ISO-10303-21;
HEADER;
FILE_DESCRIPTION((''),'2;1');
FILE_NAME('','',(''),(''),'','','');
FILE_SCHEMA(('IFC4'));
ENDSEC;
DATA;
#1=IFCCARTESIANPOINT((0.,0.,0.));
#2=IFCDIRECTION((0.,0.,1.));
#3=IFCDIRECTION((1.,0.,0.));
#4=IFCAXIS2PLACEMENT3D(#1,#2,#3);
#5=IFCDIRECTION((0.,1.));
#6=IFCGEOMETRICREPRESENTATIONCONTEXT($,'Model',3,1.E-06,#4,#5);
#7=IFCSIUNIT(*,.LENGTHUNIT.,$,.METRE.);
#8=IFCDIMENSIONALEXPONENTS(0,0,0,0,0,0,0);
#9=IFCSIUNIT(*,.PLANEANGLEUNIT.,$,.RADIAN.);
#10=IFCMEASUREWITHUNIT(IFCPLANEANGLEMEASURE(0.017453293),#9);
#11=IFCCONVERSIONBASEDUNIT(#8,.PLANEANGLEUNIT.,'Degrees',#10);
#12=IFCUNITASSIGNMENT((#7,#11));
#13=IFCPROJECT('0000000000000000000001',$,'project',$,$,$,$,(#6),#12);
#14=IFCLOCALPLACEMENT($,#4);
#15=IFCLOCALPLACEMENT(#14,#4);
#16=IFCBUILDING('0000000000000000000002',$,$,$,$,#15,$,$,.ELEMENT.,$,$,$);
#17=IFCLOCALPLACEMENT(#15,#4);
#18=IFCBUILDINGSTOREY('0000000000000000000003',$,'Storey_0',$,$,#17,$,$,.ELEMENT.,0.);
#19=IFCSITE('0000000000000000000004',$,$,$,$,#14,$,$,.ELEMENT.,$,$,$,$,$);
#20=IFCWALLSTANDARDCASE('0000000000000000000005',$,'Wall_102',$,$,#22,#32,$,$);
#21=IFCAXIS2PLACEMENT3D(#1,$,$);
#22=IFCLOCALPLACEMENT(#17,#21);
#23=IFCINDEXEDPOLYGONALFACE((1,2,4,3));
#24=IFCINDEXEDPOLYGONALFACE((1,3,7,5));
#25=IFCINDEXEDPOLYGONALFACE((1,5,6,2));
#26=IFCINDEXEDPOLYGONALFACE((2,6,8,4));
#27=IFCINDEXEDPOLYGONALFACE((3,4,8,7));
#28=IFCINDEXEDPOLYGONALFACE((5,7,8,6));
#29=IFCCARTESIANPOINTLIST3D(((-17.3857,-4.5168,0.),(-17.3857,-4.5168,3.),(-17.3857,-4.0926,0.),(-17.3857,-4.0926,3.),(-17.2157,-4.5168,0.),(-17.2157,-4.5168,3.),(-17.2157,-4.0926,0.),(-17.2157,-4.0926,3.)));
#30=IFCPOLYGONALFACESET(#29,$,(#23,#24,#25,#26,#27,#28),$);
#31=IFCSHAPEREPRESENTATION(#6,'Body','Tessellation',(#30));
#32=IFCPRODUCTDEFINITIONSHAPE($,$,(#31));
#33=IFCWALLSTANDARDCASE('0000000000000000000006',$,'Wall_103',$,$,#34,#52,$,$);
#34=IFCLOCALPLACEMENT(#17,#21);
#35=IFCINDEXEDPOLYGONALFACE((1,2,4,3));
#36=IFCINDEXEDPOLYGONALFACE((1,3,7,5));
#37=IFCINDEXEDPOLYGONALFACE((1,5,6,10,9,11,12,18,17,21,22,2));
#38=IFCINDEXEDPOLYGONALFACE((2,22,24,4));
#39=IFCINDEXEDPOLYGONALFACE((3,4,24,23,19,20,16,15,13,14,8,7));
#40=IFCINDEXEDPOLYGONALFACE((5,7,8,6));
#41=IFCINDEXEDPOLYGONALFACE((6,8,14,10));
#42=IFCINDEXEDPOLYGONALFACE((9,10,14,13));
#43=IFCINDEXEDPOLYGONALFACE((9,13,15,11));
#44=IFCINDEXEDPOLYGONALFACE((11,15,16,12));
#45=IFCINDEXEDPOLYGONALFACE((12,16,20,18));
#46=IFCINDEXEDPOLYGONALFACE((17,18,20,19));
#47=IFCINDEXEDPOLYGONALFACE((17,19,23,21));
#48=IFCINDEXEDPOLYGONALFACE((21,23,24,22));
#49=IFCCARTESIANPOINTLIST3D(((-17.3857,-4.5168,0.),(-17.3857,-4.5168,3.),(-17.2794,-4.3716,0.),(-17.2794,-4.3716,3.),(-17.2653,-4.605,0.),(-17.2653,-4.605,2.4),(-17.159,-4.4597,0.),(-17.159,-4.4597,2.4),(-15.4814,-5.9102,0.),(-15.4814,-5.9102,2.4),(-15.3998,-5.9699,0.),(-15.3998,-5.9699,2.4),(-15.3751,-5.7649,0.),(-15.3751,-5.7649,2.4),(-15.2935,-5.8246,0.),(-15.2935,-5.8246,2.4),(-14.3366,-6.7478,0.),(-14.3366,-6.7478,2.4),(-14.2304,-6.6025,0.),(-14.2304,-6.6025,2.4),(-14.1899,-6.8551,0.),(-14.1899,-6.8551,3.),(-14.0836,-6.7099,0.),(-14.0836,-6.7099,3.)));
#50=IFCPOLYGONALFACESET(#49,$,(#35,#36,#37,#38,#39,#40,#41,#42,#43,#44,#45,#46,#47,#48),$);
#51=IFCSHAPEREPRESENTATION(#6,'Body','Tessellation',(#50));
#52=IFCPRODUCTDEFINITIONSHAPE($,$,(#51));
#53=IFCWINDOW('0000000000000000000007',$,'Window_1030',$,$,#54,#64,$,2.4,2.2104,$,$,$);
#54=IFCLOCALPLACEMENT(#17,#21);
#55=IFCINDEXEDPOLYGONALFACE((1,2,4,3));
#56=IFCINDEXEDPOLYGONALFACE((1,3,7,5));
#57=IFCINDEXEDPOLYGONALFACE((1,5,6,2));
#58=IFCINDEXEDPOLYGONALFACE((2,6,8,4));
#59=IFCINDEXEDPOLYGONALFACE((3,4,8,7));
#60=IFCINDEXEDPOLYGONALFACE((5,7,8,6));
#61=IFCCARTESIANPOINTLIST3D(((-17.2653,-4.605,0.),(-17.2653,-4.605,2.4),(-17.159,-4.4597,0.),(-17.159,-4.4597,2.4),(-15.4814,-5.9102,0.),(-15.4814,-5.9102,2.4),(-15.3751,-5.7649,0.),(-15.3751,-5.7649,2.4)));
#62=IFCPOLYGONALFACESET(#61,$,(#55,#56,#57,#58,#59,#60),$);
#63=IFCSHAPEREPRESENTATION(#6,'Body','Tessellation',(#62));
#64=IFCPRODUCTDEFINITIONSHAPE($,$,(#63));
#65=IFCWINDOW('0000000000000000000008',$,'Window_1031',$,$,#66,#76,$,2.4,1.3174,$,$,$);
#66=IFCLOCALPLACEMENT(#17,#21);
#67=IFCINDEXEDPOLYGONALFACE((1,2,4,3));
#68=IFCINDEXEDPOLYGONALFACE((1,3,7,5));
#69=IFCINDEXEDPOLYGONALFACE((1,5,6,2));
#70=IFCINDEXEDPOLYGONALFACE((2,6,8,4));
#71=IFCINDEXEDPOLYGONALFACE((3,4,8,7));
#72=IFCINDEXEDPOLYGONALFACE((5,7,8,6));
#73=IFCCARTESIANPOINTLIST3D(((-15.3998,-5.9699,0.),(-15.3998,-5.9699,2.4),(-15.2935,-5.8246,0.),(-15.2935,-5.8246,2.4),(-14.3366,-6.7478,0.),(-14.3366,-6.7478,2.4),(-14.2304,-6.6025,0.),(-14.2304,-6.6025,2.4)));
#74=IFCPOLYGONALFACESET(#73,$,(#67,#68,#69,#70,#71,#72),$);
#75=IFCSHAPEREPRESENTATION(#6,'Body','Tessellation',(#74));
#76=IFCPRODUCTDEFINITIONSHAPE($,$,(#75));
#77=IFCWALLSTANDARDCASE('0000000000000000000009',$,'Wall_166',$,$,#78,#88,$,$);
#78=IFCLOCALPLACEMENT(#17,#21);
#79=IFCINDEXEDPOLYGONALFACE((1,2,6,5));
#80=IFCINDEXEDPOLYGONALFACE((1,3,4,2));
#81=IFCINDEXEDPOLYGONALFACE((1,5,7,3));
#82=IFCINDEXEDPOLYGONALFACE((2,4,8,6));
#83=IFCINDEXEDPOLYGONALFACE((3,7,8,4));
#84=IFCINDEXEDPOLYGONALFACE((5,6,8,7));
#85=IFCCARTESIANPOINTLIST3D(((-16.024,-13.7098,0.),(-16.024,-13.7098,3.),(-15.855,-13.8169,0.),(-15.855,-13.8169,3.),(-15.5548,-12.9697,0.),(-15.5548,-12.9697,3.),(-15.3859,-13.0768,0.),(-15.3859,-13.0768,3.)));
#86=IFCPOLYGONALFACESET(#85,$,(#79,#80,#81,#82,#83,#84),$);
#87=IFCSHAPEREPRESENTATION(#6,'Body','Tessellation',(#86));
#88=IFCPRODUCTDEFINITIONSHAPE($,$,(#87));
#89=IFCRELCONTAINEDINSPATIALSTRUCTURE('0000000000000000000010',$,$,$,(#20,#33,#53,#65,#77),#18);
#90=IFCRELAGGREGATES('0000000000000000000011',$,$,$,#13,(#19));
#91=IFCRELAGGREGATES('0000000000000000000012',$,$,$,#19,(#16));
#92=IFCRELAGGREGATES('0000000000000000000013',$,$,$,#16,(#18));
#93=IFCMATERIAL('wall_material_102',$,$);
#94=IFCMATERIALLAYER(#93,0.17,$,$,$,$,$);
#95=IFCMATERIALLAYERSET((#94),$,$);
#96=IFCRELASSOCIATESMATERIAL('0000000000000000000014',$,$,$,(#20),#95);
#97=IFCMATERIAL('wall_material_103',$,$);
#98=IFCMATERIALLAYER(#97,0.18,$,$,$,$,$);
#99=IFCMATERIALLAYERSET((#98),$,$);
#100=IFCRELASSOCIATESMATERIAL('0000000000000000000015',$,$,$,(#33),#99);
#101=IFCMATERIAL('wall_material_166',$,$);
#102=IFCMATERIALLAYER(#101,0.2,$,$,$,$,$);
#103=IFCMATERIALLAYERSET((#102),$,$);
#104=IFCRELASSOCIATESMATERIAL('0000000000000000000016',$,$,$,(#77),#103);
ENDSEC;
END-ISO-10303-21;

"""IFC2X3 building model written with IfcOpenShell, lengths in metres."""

from ifc_helpers import new_model, entity, si_unit, converted_unit, direction, frame, frame_2d, origin_with_axes, place, context, project, spatial, polyline, rectangle, outline, extrude, material, layer, layer_set, layer_usage, element, fill, save


model = new_model("IFC2X3")

# Units and contexts
model_context = context("Model", 3, precision=1e-06, world=origin_with_axes(), true_north=direction((0.0, 1.0)))
ifc_project = project(units=[si_unit("LENGTHUNIT", "METRE"), converted_unit("PLANEANGLEUNIT", "Degrees", entity("IfcPlaneAngleMeasure", 0.017453293), si_unit("PLANEANGLEUNIT", "RADIAN"), dimensions=[0, 0, 0, 0, 0, 0, 0])], contexts=[model_context])

# Site, building, storey
site_placement = place(None, origin_with_axes())
site = spatial("IfcSite", under=ifc_project, at=site_placement, CompositionType="ELEMENT")
building_placement = place(site_placement, origin_with_axes())
building = spatial("IfcBuilding", under=site, at=building_placement, CompositionType="ELEMENT")
storey_placement = place(building_placement, origin_with_axes())
storey = spatial("IfcBuildingStorey", under=building, at=storey_placement, Name="Storey_0", CompositionType="ELEMENT", Elevation=0.0)

# Wall
ifc_material_1 = material(Name="wall_material_102")
ifc_layer_1 = layer(ifc_material_1, 0.17)
ifc_layer_set_1 = layer_set([ifc_layer_1])
ifc_layer_usage_1 = layer_usage(ifc_layer_set_1, "AXIS2", "POSITIVE", 0.0)
wall_1_placement = place(storey_placement, frame((-17.3857, -4.0926, 0.0), z_axis=(0.0, 0.0, 1.0), x_axis=(0.0, -1.0, 0.0)))
element("IfcWallStandardCase", 1, at=wall_1_placement, inside=storey, material=ifc_layer_usage_1, Name="Wall_102", context=model_context, shape_type="SweptSolid", body=[
    extrude(outline(polyline([(0.0, 0.17), (0.4242, 0.17), (0.4242, 0.0), (0.0, 0.0), (0.0, 0.17)])), origin_with_axes(), (0.0, 0.0, 1.0), 3.0),
])

# Wall, openings, windows
ifc_material_2 = material(Name="wall_material_103")
ifc_layer_2 = layer(ifc_material_2, 0.18)
ifc_layer_set_2 = layer_set([ifc_layer_2])
ifc_layer_usage_2 = layer_usage(ifc_layer_set_2, "AXIS2", "POSITIVE", 0.0)
wall_2_placement = place(storey_placement, frame((-17.3857, -4.5168, 0.0), z_axis=(0.0, 0.0, 1.0), x_axis=(0.807044, -0.590491, 0.0)))
wall_2 = element("IfcWallStandardCase", 2, at=wall_2_placement, inside=storey, material=ifc_layer_usage_2, Name="Wall_103", context=model_context, shape_type="SweptSolid", body=[
    extrude(outline(polyline([(0.0, 0.18), (3.9599, 0.18), (3.9599, 0.0), (0.0, 0.0), (0.0, 0.18)])), origin_with_axes(), (0.0, 0.0, 1.0), 3.0),
])
opening_1_placement = place(wall_2_placement, frame((0.1493, 0.18, 0.0), z_axis=(0.0, 0.0, 1.0), x_axis=(1.0, 0.0, 0.0)))
opening_1 = element("IfcOpeningElement", 3, at=opening_1_placement, cuts=wall_2, context=model_context, shape_type="SweptSolid", body=[
    extrude(rectangle(XDim=2.2104, YDim=2.4, at=frame_2d((1.2, -1.1052), x_axis=(0.0, 1.0))), frame((0.0, 0.01, 0.0), z_axis=(0.0, -1.0, 0.0), x_axis=(0.0, 0.0, 1.0)), (0.0, 0.0, 1.0), 0.2),
])
opening_2_placement = place(wall_2_placement, frame((2.4607, 0.18, 0.0), z_axis=(0.0, 0.0, 1.0), x_axis=(1.0, 0.0, 0.0)))
opening_2 = element("IfcOpeningElement", 4, at=opening_2_placement, cuts=wall_2, context=model_context, shape_type="SweptSolid", body=[
    extrude(rectangle(XDim=1.3174, YDim=2.4, at=frame_2d((1.2, -0.6587), x_axis=(0.0, 1.0))), frame((0.0, 0.01, 0.0), z_axis=(0.0, -1.0, 0.0), x_axis=(0.0, 0.0, 1.0)), (0.0, 0.0, 1.0), 0.2),
])
window_1_placement = place(storey_placement, origin_with_axes())
window_1 = element("IfcWindow", 5, at=window_1_placement, inside=storey, Name="Window_1030", OverallHeight=2.4, OverallWidth=2.2104, context=model_context, shape_type="SweptSolid", body=[
    extrude(outline(polyline([(-17.159, -4.4597), (-15.3751, -5.7649), (-15.4814, -5.9102), (-17.2653, -4.605), (-17.159, -4.4597)])), origin_with_axes(), (0.0, 0.0, 1.0), 2.4),
])
fill(opening_1, window_1)
window_2_placement = place(storey_placement, origin_with_axes())
window_2 = element("IfcWindow", 6, at=window_2_placement, inside=storey, Name="Window_1031", OverallHeight=2.4, OverallWidth=1.3174, context=model_context, shape_type="SweptSolid", body=[
    extrude(outline(polyline([(-15.2935, -5.8246), (-14.2304, -6.6025), (-14.3366, -6.7478), (-15.3998, -5.9699), (-15.2935, -5.8246)])), origin_with_axes(), (0.0, 0.0, 1.0), 2.4),
])
fill(opening_2, window_2)

# Wall
ifc_material_3 = material(Name="wall_material_166")
ifc_layer_3 = layer(ifc_material_3, 0.2)
ifc_layer_set_3 = layer_set([ifc_layer_3])
ifc_layer_usage_3 = layer_usage(ifc_layer_set_3, "AXIS2", "NEGATIVE", 0.0)
wall_3_placement = place(storey_placement, frame((-15.3859, -13.0768, 0.0), z_axis=(0.0, 0.0, 1.0), x_axis=(-0.535385, -0.844608, 0.0)))
element("IfcWallStandardCase", 7, at=wall_3_placement, inside=storey, material=ifc_layer_usage_3, Name="Wall_166", context=model_context, shape_type="SweptSolid", body=[
    extrude(outline(polyline([(0.0, 0.0), (0.8763, 0.0), (0.8763, -0.2), (0.0, -0.2), (0.0, 0.0)])), origin_with_axes(), (0.0, 0.0, 1.0), 3.0),
])

save(model, "model.ifc")
